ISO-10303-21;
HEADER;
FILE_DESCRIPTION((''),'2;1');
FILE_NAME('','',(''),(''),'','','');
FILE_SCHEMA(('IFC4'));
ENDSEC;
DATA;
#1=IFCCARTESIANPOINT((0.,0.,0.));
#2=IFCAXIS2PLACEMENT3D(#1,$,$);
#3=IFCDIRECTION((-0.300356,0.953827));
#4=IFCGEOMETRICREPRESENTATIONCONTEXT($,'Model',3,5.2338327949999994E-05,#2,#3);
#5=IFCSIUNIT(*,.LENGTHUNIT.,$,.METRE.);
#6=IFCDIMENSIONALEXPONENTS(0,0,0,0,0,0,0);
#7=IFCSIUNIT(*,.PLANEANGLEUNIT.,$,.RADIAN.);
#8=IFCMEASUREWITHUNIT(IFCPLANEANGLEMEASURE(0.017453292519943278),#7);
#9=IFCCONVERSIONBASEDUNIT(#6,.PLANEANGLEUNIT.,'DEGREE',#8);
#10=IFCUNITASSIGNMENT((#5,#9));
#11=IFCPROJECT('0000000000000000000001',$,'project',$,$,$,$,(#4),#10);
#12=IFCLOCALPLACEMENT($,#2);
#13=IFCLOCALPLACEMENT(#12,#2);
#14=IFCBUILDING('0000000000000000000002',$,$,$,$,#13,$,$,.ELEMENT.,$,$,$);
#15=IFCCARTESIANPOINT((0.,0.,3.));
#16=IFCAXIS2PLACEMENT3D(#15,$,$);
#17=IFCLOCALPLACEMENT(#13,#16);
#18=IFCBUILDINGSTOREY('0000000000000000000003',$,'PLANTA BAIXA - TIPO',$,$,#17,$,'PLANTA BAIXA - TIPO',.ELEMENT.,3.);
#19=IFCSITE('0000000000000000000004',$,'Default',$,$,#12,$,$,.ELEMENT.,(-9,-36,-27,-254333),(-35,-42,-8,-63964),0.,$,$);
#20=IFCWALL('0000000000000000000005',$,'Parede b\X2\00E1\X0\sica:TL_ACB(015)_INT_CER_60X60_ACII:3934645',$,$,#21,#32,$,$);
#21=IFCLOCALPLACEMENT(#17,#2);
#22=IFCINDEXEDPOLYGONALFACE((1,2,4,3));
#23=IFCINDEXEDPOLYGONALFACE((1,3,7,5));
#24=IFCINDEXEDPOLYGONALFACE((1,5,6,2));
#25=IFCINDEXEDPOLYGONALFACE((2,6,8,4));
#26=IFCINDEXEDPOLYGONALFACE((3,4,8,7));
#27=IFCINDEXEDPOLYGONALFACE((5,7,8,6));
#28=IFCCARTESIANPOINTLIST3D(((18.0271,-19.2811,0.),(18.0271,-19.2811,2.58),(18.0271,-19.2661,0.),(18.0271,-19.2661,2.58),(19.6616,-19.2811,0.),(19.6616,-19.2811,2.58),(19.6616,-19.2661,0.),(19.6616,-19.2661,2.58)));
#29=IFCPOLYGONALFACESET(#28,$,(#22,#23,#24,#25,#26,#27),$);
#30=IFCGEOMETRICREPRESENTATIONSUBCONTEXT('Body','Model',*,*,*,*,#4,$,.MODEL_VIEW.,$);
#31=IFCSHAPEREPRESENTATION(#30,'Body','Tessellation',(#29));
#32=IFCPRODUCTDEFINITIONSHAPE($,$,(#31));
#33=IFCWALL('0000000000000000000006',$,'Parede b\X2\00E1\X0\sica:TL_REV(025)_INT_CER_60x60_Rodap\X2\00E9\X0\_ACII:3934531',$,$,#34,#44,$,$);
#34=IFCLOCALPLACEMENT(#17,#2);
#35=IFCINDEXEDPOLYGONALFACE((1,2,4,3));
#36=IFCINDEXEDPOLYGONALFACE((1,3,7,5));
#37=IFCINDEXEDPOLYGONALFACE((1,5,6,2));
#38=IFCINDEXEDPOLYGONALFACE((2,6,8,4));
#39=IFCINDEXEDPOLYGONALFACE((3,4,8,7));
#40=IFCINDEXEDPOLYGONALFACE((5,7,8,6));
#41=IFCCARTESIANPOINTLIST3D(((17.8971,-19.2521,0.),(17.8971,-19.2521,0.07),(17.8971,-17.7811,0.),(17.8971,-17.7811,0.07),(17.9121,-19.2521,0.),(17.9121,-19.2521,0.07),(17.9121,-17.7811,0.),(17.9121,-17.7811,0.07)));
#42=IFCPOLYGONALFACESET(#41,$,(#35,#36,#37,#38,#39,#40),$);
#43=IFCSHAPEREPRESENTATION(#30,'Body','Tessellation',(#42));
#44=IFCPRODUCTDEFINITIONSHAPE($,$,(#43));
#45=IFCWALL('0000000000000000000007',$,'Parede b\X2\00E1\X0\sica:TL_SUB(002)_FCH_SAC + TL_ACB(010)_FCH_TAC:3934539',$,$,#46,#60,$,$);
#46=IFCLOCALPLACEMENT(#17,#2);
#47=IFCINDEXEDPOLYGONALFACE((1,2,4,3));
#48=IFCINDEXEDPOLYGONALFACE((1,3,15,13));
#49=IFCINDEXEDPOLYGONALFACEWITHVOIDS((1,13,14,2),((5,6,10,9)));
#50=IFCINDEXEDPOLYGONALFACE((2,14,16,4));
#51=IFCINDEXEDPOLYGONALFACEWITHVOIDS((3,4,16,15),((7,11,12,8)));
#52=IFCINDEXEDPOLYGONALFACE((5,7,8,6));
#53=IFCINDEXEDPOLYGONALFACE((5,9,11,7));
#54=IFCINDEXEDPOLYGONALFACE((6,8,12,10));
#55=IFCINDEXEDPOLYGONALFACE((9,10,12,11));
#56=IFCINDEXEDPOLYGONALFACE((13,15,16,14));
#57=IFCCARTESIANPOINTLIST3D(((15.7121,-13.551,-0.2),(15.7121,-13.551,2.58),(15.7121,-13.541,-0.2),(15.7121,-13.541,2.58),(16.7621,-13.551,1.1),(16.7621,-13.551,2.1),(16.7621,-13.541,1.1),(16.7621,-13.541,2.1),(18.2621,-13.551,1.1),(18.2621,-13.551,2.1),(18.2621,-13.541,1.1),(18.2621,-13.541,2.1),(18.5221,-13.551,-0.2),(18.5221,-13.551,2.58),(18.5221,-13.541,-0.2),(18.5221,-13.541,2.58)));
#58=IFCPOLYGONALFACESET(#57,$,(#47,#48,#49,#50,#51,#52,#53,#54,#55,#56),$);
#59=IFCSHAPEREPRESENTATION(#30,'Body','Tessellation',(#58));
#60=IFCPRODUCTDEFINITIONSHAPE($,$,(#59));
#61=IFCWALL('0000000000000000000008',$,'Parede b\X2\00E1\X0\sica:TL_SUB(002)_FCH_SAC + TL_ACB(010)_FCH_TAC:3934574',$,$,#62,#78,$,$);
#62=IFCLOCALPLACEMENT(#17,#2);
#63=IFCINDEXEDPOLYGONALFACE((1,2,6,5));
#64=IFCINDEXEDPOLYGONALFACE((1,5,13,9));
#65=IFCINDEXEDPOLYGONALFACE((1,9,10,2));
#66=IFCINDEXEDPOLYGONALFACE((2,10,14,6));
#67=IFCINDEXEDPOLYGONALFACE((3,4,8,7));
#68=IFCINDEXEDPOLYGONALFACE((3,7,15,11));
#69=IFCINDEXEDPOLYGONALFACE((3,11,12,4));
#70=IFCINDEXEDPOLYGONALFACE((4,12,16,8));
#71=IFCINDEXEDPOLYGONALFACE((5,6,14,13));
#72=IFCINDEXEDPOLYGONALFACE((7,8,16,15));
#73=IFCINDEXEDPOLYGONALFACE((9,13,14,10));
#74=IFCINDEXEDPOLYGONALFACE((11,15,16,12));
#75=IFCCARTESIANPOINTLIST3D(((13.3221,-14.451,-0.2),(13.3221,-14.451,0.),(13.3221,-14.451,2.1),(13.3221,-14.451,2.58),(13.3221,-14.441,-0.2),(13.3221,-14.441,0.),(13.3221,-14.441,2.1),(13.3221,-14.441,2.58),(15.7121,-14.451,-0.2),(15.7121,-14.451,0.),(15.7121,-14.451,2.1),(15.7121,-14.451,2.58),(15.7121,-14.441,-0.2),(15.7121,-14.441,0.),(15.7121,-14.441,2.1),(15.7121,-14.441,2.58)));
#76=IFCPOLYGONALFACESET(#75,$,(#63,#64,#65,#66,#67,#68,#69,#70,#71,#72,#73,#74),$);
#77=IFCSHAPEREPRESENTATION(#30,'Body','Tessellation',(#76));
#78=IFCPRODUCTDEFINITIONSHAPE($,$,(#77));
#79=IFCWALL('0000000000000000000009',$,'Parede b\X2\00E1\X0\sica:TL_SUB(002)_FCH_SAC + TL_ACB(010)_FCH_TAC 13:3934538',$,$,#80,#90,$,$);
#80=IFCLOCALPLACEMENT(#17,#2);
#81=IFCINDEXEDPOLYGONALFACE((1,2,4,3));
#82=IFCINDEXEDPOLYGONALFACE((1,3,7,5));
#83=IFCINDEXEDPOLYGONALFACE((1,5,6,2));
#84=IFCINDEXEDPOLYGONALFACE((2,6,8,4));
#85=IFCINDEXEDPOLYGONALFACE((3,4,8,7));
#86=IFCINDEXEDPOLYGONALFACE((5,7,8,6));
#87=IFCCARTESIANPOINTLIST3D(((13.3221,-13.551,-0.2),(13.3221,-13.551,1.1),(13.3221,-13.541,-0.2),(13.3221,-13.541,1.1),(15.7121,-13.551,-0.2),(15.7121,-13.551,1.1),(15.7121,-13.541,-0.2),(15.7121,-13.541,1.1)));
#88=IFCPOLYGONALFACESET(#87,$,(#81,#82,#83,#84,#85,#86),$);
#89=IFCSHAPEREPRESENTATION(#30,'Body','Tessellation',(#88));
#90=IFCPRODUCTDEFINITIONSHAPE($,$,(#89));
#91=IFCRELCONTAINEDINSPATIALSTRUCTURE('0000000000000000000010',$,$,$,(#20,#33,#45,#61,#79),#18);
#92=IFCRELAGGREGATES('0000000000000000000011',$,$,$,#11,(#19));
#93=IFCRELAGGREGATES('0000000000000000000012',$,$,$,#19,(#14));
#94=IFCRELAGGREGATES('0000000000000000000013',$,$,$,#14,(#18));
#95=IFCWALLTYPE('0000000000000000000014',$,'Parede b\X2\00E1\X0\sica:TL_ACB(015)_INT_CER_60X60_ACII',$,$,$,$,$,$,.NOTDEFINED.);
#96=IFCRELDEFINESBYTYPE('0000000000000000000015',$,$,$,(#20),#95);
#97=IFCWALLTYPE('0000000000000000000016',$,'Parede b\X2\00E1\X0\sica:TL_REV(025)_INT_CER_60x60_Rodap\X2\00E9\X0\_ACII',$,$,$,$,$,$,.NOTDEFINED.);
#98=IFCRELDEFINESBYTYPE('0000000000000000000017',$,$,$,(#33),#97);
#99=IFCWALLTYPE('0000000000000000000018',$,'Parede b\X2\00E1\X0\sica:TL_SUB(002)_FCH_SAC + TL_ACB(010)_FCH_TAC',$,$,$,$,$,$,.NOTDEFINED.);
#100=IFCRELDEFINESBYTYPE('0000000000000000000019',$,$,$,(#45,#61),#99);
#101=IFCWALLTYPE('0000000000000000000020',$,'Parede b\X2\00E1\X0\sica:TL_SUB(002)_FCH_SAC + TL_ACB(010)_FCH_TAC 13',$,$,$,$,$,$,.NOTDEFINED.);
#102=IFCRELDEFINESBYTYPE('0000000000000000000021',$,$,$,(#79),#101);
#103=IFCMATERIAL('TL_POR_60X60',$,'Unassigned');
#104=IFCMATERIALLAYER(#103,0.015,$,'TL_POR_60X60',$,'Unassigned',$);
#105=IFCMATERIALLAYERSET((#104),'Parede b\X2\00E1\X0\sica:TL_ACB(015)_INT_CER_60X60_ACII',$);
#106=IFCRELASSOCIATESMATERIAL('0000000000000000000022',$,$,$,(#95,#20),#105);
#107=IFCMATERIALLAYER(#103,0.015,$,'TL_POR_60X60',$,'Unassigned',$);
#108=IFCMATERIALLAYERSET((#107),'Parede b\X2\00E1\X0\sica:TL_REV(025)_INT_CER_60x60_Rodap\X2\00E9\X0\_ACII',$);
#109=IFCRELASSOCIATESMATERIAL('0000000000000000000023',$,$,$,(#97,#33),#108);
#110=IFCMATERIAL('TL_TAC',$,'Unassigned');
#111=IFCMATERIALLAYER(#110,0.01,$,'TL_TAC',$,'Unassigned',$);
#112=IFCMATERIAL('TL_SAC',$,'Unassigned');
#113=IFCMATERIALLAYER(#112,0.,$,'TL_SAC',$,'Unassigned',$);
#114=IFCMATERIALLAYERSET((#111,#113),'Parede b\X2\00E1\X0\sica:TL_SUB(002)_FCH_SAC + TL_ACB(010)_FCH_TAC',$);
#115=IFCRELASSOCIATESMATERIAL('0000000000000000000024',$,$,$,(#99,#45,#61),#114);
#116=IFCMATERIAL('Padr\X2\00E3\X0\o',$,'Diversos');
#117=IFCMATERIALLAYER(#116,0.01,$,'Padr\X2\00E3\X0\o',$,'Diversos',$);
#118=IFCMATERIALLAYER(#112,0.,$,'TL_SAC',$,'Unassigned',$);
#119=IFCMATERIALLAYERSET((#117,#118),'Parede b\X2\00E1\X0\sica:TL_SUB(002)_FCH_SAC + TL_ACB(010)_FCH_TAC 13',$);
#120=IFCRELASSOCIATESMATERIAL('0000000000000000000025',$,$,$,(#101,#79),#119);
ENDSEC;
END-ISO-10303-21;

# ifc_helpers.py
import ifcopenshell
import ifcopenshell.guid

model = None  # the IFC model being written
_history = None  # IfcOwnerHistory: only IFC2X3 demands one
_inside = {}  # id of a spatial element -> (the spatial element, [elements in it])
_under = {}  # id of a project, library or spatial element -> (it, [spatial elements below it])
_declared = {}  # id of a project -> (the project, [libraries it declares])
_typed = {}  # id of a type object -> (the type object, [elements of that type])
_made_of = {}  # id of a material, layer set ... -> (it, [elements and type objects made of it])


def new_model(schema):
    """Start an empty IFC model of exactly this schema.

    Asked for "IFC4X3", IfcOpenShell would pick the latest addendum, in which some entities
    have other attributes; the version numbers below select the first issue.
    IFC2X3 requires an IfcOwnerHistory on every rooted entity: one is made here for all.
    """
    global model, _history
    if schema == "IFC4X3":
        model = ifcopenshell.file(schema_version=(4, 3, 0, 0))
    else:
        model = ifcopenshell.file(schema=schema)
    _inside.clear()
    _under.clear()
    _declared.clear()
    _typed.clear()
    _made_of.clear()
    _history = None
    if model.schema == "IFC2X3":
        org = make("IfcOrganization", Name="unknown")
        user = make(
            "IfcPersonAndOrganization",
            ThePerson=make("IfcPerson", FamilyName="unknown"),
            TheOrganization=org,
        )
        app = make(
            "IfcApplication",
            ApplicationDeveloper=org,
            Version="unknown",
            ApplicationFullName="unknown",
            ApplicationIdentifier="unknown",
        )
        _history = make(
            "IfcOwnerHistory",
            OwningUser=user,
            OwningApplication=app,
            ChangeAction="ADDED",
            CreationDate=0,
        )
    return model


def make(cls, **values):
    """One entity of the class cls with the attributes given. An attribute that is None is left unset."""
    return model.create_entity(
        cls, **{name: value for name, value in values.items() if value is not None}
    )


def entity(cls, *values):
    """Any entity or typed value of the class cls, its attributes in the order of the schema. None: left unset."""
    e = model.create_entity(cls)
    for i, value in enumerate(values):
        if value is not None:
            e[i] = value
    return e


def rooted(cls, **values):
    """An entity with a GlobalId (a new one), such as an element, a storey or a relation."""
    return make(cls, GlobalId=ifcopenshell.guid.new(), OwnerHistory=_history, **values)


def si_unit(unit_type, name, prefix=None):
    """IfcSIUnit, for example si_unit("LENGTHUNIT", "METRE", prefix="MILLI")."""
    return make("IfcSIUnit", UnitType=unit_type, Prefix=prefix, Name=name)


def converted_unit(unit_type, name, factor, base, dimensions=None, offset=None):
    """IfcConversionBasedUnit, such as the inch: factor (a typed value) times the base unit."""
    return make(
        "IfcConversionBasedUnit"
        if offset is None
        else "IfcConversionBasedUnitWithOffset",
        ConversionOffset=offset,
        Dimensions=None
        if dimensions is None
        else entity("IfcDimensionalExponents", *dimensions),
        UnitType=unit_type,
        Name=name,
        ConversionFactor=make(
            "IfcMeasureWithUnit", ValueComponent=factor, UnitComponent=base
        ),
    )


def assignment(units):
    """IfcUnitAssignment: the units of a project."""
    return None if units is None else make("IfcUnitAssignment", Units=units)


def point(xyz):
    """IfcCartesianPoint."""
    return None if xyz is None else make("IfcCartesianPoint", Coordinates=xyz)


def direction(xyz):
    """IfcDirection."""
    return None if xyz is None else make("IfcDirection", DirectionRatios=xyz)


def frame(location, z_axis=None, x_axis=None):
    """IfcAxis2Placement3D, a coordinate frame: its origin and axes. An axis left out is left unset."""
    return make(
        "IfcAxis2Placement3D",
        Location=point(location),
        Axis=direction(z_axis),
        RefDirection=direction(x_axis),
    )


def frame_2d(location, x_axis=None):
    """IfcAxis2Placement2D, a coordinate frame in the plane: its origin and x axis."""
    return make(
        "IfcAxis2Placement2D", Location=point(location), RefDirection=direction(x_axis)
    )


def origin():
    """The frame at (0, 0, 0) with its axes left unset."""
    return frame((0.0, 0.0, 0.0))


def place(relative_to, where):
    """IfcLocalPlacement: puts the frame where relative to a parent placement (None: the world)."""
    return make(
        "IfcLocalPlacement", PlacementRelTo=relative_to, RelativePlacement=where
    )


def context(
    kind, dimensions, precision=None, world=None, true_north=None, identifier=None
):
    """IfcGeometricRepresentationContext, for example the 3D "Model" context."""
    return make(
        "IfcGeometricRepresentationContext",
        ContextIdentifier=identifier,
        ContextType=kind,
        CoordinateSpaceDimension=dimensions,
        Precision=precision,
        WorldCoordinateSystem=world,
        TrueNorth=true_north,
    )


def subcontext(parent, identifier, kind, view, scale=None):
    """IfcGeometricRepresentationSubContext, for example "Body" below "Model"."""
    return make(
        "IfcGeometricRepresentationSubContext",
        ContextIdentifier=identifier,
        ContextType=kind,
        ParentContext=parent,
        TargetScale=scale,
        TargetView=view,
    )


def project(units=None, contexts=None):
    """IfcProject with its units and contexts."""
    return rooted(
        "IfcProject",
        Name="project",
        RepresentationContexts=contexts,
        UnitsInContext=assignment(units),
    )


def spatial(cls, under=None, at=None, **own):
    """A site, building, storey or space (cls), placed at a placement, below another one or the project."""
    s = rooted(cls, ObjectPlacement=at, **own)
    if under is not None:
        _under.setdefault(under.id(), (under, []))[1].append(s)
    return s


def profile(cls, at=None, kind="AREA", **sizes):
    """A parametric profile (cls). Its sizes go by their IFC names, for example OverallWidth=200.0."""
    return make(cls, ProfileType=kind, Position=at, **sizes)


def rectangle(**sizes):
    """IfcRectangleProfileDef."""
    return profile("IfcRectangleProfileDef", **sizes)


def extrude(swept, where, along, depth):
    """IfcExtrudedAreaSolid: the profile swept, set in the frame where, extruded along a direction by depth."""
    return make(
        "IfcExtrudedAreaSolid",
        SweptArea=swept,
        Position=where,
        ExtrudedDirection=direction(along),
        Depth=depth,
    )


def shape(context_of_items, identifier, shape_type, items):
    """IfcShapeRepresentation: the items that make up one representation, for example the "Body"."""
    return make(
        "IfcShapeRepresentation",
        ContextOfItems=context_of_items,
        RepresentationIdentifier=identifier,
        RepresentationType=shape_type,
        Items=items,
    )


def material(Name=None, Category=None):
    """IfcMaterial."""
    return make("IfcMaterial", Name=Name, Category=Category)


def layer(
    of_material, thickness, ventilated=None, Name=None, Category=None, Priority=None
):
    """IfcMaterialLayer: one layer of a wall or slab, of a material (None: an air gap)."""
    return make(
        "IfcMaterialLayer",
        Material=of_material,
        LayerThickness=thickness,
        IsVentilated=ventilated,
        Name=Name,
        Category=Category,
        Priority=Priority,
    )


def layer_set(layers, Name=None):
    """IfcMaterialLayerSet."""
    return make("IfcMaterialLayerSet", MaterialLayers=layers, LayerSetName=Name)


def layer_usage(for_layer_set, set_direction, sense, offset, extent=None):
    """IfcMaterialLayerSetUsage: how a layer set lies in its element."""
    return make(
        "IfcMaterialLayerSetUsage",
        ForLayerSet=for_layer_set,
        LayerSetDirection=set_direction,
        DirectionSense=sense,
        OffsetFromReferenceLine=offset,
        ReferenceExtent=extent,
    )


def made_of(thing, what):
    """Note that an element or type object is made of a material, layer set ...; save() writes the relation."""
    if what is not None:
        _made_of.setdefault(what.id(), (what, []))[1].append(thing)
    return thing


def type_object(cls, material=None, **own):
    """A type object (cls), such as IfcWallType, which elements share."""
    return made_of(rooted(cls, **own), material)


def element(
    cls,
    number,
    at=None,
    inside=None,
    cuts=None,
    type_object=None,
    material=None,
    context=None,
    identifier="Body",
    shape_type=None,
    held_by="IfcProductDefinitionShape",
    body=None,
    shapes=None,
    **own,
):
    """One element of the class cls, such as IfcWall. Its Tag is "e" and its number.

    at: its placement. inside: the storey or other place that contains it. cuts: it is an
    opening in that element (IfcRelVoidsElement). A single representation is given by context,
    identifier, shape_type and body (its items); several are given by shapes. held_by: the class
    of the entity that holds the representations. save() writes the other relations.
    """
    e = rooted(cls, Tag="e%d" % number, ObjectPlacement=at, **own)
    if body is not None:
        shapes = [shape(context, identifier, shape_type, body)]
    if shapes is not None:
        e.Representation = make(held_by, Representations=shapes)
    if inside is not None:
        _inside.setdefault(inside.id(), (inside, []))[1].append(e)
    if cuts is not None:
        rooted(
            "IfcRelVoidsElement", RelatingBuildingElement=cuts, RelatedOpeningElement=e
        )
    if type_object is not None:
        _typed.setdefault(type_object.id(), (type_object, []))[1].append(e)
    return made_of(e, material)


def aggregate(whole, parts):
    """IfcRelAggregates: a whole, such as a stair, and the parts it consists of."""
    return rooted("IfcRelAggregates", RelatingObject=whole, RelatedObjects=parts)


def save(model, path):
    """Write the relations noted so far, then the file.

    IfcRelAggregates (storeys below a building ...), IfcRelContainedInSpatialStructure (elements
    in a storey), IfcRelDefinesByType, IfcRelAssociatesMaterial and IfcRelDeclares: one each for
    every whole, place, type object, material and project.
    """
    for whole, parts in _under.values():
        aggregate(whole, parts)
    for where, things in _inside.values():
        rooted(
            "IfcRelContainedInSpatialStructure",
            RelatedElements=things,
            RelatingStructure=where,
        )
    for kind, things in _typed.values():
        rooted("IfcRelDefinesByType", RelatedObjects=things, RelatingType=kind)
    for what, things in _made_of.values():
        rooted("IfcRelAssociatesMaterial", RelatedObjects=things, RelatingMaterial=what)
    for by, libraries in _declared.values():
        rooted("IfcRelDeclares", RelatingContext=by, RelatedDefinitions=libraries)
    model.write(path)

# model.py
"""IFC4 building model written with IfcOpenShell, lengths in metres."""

from ifc_helpers import new_model, entity, si_unit, converted_unit, direction, frame, frame_2d, origin, place, context, subcontext, project, spatial, rectangle, extrude, material, layer, layer_set, layer_usage, type_object, element, save


model = new_model("IFC4")

# Units and contexts
model_context = context("Model", 3, precision=5.2338327949999994e-05, world=origin(), true_north=direction((-0.300356, 0.953827)))
body_context = subcontext(model_context, "Body", "Model", "MODEL_VIEW")
ifc_project = project(units=[si_unit("LENGTHUNIT", "METRE"), converted_unit("PLANEANGLEUNIT", "DEGREE", entity("IfcPlaneAngleMeasure", 0.017453292519943278), si_unit("PLANEANGLEUNIT", "RADIAN"), dimensions=[0, 0, 0, 0, 0, 0, 0])], contexts=[model_context])

# Site, building, storey
site_placement = place(None, origin())
site = spatial("IfcSite", under=ifc_project, at=site_placement, Name="Default", CompositionType="ELEMENT", RefLatitude=(-9, -36, -27, -254333), RefLongitude=(-35, -42, -8, -63964), RefElevation=0.0)
building_placement = place(site_placement, origin())
building = spatial("IfcBuilding", under=site, at=building_placement, CompositionType="ELEMENT")
storey_placement = place(building_placement, frame((0.0, 0.0, 3.0)))
storey = spatial("IfcBuildingStorey", under=building, at=storey_placement, Name="PLANTA BAIXA - TIPO", LongName="PLANTA BAIXA - TIPO", CompositionType="ELEMENT", Elevation=3.0)

# Shared definitions
ifc_material_1 = material(Name="TL_SAC", Category="Unassigned")

# Walls
ifc_material_2 = material(Name="TL_POR_60X60", Category="Unassigned")
ifc_layer_1 = layer(ifc_material_2, 0.015, Name="TL_POR_60X60", Category="Unassigned")
ifc_layer_set_1 = layer_set([ifc_layer_1], Name="Parede básica:TL_ACB(015)_INT_CER_60X60_ACII")
wall_type_1 = type_object("IfcWallType", Name="Parede básica:TL_ACB(015)_INT_CER_60X60_ACII", PredefinedType="NOTDEFINED", material=ifc_layer_set_1)
ifc_layer_usage_1 = layer_usage(ifc_layer_set_1, "AXIS2", "NEGATIVE", 0.0075)
wall_1_placement = place(storey_placement, frame((18.0271, -19.2736, 0.0)))
element("IfcWall", 1, at=wall_1_placement, inside=storey, type_object=wall_type_1, material=ifc_layer_usage_1, Name="Parede básica:TL_ACB(015)_INT_CER_60X60_ACII:3934645", context=body_context, shape_type="SweptSolid", body=[
    extrude(rectangle(XDim=1.6345, YDim=0.015, at=frame_2d((0.8172, 0.0), x_axis=(-1.0, 0.0))), origin(), (0.0, 0.0, 1.0), 2.58),
])
ifc_layer_2 = layer(ifc_material_2, 0.015, Name="TL_POR_60X60", Category="Unassigned")
ifc_layer_set_2 = layer_set([ifc_layer_2], Name="Parede básica:TL_REV(025)_INT_CER_60x60_Rodapé_ACII")
ifc_layer_usage_2 = layer_usage(ifc_layer_set_2, "AXIS2", "NEGATIVE", 0.0075)
wall_type_2 = type_object("IfcWallType", Name="Parede básica:TL_REV(025)_INT_CER_60x60_Rodapé_ACII", PredefinedType="NOTDEFINED", material=ifc_layer_set_2)
wall_2_placement = place(storey_placement, frame((17.9046, -19.2521, 0.0), z_axis=(0.0, 0.0, 1.0), x_axis=(0.0, 1.0, 0.0)))
element("IfcWall", 2, at=wall_2_placement, inside=storey, type_object=wall_type_2, material=ifc_layer_usage_2, Name="Parede básica:TL_REV(025)_INT_CER_60x60_Rodapé_ACII:3934531", context=body_context, shape_type="SweptSolid", body=[
    extrude(rectangle(XDim=1.471, YDim=0.015, at=frame_2d((0.7355, 0.0), x_axis=(-1.0, 0.0))), origin(), (0.0, 0.0, 1.0), 0.07),
])

# Walls, openings
ifc_material_3 = material(Name="TL_TAC", Category="Unassigned")
ifc_layer_3 = layer(ifc_material_3, 0.01, Name="TL_TAC", Category="Unassigned")
ifc_layer_4 = layer(ifc_material_1, 0.0, Name="TL_SAC", Category="Unassigned")
ifc_layer_set_3 = layer_set([ifc_layer_3, ifc_layer_4], Name="Parede básica:TL_SUB(002)_FCH_SAC + TL_ACB(010)_FCH_TAC")
ifc_layer_usage_3 = layer_usage(ifc_layer_set_3, "AXIS2", "NEGATIVE", 0.005)
wall_type_3 = type_object("IfcWallType", Name="Parede básica:TL_SUB(002)_FCH_SAC + TL_ACB(010)_FCH_TAC", PredefinedType="NOTDEFINED", material=ifc_layer_set_3)
wall_3_placement = place(storey_placement, frame((15.7121, -13.546, -0.2)))
wall_3 = element("IfcWall", 3, at=wall_3_placement, inside=storey, type_object=wall_type_3, material=ifc_layer_usage_3, Name="Parede básica:TL_SUB(002)_FCH_SAC + TL_ACB(010)_FCH_TAC:3934539", context=body_context, shape_type="SweptSolid", body=[
    extrude(rectangle(XDim=2.81, YDim=0.01, at=frame_2d((1.405, 0.0), x_axis=(-1.0, 0.0))), origin(), (0.0, 0.0, 1.0), 2.78),
])
opening_1_placement = place(wall_3_placement, frame((-15.7121, 13.546, 1.3)))
element("IfcOpeningElement", 4, at=opening_1_placement, cuts=wall_3, PredefinedType="OPENING", context=body_context, shape_type="SweptSolid", body=[
    extrude(rectangle(XDim=1.0, YDim=1.5, at=frame_2d((0.0, 0.0), x_axis=(0.0, 1.0))), frame((17.5121, -15.175, 0.5), z_axis=(0.0, 1.0, 0.0), x_axis=(1.0, 0.0, 0.0)), (0.0, 0.0, 1.0), 3.048),
])
ifc_layer_usage_4 = layer_usage(ifc_layer_set_3, "AXIS2", "NEGATIVE", 0.005)
wall_4_placement = place(storey_placement, frame((13.3221, -14.446, -0.2)))
wall_4 = element("IfcWall", 5, at=wall_4_placement, inside=storey, type_object=wall_type_3, material=ifc_layer_usage_4, Name="Parede básica:TL_SUB(002)_FCH_SAC + TL_ACB(010)_FCH_TAC:3934574", context=body_context, shape_type="SweptSolid", body=[
    extrude(rectangle(XDim=2.39, YDim=0.01, at=frame_2d((1.195, 0.0), x_axis=(-1.0, 0.0))), origin(), (0.0, 0.0, 1.0), 2.78),
])
opening_2_placement = place(wall_4_placement, frame((-13.3221, 14.446, 0.2)))
element("IfcOpeningElement", 6, at=opening_2_placement, cuts=wall_4, PredefinedType="OPENING", context=body_context, shape_type="SweptSolid", body=[
    extrude(rectangle(XDim=2.1, YDim=2.4, at=frame_2d((0.0, 0.0), x_axis=(0.0, 1.0))), frame((14.5121, -15.975, 1.05), z_axis=(0.0, 1.0, 0.0), x_axis=(-1.0, 0.0, 0.0)), (0.0, 0.0, 1.0), 3.048),
])

# Wall
ifc_material_4 = material(Name="Padrão", Category="Diversos")
ifc_layer_5 = layer(ifc_material_4, 0.01, Name="Padrão", Category="Diversos")
ifc_layer_6 = layer(ifc_material_1, 0.0, Name="TL_SAC", Category="Unassigned")
ifc_layer_set_4 = layer_set([ifc_layer_5, ifc_layer_6], Name="Parede básica:TL_SUB(002)_FCH_SAC + TL_ACB(010)_FCH_TAC 13")
ifc_layer_usage_5 = layer_usage(ifc_layer_set_4, "AXIS2", "POSITIVE", -0.005)
wall_type_4 = type_object("IfcWallType", Name="Parede básica:TL_SUB(002)_FCH_SAC + TL_ACB(010)_FCH_TAC 13", PredefinedType="NOTDEFINED", material=ifc_layer_set_4)
wall_5_placement = place(storey_placement, frame((13.3221, -13.546, -0.2)))
element("IfcWall", 7, at=wall_5_placement, inside=storey, type_object=wall_type_4, material=ifc_layer_usage_5, Name="Parede básica:TL_SUB(002)_FCH_SAC + TL_ACB(010)_FCH_TAC 13:3934538", context=body_context, shape_type="SweptSolid", body=[
    extrude(rectangle(XDim=2.39, YDim=0.01, at=frame_2d((1.195, 0.0), x_axis=(-1.0, 0.0))), origin(), (0.0, 0.0, 1.0), 1.3),
])

save(model, "model.ifc")
